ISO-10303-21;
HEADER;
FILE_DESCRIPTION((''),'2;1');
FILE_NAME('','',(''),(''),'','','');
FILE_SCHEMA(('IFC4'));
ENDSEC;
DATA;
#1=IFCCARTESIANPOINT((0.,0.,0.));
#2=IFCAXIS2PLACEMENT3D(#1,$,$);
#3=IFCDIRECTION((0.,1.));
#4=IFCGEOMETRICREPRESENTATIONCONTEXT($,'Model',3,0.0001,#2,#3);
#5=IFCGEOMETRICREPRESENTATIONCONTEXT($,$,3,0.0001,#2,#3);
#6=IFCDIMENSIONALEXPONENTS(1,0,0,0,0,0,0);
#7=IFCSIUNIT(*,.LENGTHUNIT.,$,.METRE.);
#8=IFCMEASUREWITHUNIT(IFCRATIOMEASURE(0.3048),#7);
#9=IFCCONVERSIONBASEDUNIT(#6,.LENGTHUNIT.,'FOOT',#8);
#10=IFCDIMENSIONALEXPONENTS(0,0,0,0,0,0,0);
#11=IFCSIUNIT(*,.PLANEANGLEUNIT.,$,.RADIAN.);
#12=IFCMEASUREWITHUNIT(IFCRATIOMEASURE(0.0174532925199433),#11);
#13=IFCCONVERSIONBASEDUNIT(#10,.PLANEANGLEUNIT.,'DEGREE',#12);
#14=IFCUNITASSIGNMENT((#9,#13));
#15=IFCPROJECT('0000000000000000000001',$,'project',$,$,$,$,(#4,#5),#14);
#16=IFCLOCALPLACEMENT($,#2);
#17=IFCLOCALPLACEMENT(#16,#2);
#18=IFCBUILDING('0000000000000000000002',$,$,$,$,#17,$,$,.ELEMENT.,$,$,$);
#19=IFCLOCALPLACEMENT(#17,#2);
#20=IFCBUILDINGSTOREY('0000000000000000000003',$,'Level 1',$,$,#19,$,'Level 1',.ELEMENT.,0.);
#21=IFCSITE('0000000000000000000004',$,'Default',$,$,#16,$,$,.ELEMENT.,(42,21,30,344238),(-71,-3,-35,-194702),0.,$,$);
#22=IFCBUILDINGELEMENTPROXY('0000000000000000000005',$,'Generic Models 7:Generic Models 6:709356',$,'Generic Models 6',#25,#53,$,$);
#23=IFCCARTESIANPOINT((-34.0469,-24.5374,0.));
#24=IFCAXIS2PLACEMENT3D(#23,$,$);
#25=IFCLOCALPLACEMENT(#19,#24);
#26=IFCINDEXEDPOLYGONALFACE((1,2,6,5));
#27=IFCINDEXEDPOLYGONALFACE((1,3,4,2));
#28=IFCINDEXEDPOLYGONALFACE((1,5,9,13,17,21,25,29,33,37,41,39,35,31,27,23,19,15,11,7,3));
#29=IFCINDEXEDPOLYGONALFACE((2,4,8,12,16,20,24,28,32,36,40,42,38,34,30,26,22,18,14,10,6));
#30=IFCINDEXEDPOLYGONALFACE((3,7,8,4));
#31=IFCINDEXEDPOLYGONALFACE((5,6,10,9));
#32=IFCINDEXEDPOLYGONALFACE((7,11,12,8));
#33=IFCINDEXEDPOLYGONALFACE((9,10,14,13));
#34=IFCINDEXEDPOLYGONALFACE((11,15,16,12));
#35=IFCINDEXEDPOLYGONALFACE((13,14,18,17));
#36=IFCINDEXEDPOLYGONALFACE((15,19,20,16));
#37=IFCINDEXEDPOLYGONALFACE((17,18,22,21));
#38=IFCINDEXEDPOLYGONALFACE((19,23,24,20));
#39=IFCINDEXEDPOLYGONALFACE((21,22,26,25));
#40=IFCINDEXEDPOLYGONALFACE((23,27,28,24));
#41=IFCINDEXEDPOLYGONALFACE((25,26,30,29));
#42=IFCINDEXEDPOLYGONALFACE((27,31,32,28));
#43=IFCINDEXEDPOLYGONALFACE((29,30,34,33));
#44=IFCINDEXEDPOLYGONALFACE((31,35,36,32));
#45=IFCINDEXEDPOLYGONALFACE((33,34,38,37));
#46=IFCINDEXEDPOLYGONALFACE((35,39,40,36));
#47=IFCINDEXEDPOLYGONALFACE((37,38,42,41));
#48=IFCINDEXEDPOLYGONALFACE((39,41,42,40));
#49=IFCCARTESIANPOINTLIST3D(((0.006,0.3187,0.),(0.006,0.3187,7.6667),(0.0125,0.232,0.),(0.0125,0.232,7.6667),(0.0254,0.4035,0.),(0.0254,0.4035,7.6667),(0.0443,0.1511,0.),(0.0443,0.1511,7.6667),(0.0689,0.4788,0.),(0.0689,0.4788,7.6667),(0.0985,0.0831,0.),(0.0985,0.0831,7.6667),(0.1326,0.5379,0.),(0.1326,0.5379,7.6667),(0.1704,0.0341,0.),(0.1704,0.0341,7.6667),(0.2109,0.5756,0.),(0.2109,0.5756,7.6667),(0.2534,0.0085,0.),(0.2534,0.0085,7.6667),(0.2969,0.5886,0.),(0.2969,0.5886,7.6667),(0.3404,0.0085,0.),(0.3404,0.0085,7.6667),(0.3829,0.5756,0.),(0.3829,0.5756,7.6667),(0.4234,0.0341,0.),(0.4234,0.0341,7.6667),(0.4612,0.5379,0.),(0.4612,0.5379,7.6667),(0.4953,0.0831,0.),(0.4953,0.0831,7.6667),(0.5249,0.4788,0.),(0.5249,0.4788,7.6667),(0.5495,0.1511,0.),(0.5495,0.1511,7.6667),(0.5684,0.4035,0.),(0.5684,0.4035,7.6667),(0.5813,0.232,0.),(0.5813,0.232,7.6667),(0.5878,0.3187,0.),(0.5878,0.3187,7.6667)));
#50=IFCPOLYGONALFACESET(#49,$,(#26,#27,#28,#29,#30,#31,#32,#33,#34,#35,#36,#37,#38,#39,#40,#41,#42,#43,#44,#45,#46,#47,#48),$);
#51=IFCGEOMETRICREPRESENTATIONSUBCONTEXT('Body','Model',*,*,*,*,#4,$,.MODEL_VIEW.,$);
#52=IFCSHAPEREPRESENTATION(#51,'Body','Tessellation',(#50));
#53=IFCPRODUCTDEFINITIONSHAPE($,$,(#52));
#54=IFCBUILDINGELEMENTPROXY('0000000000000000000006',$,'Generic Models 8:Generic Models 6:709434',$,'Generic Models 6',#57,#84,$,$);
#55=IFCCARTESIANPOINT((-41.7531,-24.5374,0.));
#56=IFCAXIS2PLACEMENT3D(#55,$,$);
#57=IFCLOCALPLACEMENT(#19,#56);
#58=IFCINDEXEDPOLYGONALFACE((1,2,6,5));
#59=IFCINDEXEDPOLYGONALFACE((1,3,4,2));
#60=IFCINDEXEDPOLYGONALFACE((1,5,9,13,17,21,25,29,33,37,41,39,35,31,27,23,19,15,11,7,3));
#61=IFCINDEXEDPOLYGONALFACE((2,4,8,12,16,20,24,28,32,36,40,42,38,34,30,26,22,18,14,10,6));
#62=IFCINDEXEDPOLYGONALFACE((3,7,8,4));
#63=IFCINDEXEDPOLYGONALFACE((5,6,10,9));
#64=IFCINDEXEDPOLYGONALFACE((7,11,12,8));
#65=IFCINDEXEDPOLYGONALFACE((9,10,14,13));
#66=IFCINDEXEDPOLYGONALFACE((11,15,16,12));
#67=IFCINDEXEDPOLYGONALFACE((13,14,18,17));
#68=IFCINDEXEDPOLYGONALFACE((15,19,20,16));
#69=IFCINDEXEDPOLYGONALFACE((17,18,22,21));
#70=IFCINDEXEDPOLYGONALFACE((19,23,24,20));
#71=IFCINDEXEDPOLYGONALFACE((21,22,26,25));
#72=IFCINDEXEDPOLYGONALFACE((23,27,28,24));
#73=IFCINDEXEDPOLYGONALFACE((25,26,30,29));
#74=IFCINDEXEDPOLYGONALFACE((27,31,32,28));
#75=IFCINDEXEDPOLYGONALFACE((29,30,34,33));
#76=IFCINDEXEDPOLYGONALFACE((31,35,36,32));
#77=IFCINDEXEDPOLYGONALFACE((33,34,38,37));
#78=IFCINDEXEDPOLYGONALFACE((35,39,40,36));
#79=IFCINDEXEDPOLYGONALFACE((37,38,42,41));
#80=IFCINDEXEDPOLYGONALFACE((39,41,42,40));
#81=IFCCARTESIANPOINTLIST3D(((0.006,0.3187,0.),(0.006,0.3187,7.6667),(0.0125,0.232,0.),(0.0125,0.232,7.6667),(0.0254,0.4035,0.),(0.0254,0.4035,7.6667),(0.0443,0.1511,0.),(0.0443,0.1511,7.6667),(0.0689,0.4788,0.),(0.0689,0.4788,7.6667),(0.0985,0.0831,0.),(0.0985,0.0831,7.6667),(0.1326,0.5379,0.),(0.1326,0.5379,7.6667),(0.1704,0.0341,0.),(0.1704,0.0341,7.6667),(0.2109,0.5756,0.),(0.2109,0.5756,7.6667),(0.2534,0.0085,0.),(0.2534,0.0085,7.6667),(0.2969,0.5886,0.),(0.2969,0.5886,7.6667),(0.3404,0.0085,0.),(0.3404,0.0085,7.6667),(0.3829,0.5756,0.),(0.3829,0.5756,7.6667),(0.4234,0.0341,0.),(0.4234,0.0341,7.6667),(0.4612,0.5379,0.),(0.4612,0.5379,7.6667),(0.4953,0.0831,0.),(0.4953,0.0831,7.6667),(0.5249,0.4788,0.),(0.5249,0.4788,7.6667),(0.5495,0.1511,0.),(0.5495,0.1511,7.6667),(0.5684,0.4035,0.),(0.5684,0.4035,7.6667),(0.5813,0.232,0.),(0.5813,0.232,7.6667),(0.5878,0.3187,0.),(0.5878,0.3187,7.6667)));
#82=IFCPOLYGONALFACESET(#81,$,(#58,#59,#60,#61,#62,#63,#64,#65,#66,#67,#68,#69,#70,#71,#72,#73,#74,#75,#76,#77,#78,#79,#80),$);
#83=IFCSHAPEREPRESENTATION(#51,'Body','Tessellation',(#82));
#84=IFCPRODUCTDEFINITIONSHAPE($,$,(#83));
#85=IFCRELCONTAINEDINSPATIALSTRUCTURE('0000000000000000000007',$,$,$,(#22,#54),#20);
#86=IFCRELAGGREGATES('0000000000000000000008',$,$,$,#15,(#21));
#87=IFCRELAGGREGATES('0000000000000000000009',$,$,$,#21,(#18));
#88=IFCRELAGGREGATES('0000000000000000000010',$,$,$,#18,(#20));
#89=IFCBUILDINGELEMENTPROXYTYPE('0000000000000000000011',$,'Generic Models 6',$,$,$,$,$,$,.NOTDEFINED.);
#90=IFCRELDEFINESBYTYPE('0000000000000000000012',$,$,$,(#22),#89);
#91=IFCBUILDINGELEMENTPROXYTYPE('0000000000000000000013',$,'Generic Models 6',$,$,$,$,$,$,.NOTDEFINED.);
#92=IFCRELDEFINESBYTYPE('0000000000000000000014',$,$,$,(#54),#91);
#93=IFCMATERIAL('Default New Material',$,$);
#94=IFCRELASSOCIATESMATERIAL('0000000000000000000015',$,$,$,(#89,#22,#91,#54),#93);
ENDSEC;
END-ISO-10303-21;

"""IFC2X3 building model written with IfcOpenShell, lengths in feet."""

from ifc_helpers import new_model, entity, si_unit, converted_unit, direction, frame, origin, origin_2d_with_axis, place, context, subcontext, project, spatial, circle, extrude, source, transform, mapped, material, type_object, type_shapes, element, save


model = new_model("IFC2X3")

# Units and contexts
model_context = context("Model", 3, precision=0.0001, world=origin(), true_north=direction((0.0, 1.0)))
context_of_model = context(None, 3, precision=0.0001, world=origin(), true_north=direction((0.0, 1.0)))
body_context = subcontext(model_context, "Body", "Model", "MODEL_VIEW")
ifc_project = project(units=[converted_unit("LENGTHUNIT", "FOOT", entity("IfcRatioMeasure", 0.3048), si_unit("LENGTHUNIT", "METRE"), dimensions=[1, 0, 0, 0, 0, 0, 0]), converted_unit("PLANEANGLEUNIT", "DEGREE", entity("IfcRatioMeasure", 0.0174532925199433), si_unit("PLANEANGLEUNIT", "RADIAN"), dimensions=[0, 0, 0, 0, 0, 0, 0])], contexts=[model_context, context_of_model])

# Site, building, storey
site_placement = place(None, origin())
site = spatial("IfcSite", under=ifc_project, at=site_placement, Name="Default", CompositionType="ELEMENT", RefLatitude=(42, 21, 30, 344238), RefLongitude=(-71, -3, -35, -194702), RefElevation=0.0)
building_placement = place(site_placement, origin())
building = spatial("IfcBuilding", under=site, at=building_placement, CompositionType="ELEMENT")
storey_placement = place(building_placement, origin())
storey = spatial("IfcBuildingStorey", under=building, at=storey_placement, Name="Level 1", LongName="Level 1", CompositionType="ELEMENT", Elevation=0.0)

# Shared definitions
ifc_material_1 = material(Name="Default New Material")

# Building element proxies
building_element_proxy_type_1 = type_object("IfcBuildingElementProxyType", Name="Generic Models 6", PredefinedType="NOTDEFINED", material=ifc_material_1)
shared_shape_1 = source(origin(), body_context, "Body", "SweptSolid", [
    extrude(circle(Radius=0.2917, at=origin_2d_with_axis()), frame((0.2969, 0.2969, 0.0), z_axis=(0.0, 0.0, 1.0), x_axis=(0.0, 1.0, 0.0)), (0.0, 0.0, 1.0), 7.6667),
])
type_shapes(building_element_proxy_type_1, [shared_shape_1])
proxy_1_placement = place(storey_placement, frame((-34.0469, -24.5374, 0.0)))
element("IfcBuildingElementProxy", 1, at=proxy_1_placement, inside=storey, type_object=building_element_proxy_type_1, material=ifc_material_1, Name="Generic Models 7:Generic Models 6:709356", ObjectType="Generic Models 6", context=body_context, shape_type="MappedRepresentation", body=[
    mapped(shared_shape_1, transform((0.0, 0.0, 0.0), scale=1.0)),
])
building_element_proxy_type_2 = type_object("IfcBuildingElementProxyType", Name="Generic Models 6", PredefinedType="NOTDEFINED", material=ifc_material_1)
shared_shape_2 = source(origin(), body_context, "Body", "SweptSolid", [
    extrude(circle(Radius=0.2917, at=origin_2d_with_axis()), frame((0.2969, 0.2969, 0.0), z_axis=(0.0, 0.0, 1.0), x_axis=(0.0, 1.0, 0.0)), (0.0, 0.0, 1.0), 7.6667),
])
type_shapes(building_element_proxy_type_2, [shared_shape_2])
proxy_2_placement = place(storey_placement, frame((-41.7531, -24.5374, 0.0)))
element("IfcBuildingElementProxy", 2, at=proxy_2_placement, inside=storey, type_object=building_element_proxy_type_2, material=ifc_material_1, Name="Generic Models 8:Generic Models 6:709434", ObjectType="Generic Models 6", context=body_context, shape_type="MappedRepresentation", body=[
    mapped(shared_shape_2, transform((0.0, 0.0, 0.0), scale=1.0)),
])

save(model, "model.ifc")
